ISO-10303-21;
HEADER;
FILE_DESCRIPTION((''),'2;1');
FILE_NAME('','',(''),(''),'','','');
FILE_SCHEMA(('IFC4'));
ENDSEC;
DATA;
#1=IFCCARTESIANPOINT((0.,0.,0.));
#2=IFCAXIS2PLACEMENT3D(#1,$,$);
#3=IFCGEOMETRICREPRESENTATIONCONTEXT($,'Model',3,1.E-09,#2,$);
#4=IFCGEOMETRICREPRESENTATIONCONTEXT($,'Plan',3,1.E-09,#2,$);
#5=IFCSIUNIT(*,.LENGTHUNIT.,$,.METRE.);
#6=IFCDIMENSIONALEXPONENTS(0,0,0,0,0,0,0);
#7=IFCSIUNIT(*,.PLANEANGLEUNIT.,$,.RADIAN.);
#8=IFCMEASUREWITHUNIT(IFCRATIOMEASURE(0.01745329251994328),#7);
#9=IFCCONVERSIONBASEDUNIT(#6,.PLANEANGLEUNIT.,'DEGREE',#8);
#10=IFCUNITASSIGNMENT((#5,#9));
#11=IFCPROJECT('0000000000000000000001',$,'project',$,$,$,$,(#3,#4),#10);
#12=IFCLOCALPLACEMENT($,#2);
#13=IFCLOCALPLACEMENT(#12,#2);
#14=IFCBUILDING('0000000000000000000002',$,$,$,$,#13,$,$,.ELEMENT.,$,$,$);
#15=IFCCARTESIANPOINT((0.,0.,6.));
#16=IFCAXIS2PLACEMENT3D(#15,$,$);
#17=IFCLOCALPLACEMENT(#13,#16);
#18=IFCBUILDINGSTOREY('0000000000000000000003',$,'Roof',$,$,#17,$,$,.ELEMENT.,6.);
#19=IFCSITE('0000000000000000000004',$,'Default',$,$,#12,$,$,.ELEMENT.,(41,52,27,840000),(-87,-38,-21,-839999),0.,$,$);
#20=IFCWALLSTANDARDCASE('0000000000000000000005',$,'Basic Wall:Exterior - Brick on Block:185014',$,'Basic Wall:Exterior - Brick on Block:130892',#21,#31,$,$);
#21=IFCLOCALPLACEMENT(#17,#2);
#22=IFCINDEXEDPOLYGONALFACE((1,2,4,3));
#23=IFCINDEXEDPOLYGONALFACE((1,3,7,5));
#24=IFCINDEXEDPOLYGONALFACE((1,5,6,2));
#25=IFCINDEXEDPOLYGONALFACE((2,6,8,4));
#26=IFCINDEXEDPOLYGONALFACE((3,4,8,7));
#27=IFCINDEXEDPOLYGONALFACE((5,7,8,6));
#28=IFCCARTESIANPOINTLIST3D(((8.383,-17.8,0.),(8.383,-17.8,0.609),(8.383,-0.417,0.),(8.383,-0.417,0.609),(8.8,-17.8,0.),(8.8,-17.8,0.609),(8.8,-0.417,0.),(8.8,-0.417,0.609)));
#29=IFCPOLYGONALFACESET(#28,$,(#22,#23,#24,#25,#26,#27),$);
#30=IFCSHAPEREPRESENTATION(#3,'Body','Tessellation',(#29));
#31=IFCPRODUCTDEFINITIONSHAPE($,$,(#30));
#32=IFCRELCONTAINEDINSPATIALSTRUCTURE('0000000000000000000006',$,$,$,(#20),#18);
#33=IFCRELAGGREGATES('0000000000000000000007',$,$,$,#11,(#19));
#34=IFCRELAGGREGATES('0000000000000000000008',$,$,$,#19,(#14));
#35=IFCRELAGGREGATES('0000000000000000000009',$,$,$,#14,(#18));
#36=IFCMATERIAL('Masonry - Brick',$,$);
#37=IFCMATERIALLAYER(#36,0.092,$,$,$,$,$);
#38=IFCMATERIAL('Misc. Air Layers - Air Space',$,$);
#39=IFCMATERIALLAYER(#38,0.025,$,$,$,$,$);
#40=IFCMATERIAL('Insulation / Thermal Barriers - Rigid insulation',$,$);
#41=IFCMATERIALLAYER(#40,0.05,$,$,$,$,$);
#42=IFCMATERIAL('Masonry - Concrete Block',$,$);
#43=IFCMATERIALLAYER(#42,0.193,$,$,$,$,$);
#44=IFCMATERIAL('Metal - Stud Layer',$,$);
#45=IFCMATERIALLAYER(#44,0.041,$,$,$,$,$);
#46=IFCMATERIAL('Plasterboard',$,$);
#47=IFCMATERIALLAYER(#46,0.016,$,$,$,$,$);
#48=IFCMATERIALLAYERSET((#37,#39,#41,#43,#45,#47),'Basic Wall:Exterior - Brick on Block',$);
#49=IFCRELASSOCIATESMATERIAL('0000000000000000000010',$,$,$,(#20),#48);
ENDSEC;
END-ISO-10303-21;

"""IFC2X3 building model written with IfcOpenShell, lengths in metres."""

from ifc_helpers import new_model, entity, si_unit, converted_unit, frame, frame_2d, origin, place, context, project, spatial, rectangle, extrude, material, layer, layer_set, layer_usage, element, save


model = new_model("IFC2X3")

# Units and contexts
model_context = context("Model", 3, precision=1e-09, world=origin())
plan_context = context("Plan", 3, precision=1e-09, world=origin())
ifc_project = project(units=[si_unit("LENGTHUNIT", "METRE"), converted_unit("PLANEANGLEUNIT", "DEGREE", entity("IfcRatioMeasure", 0.01745329251994328), si_unit("PLANEANGLEUNIT", "RADIAN"), dimensions=[0, 0, 0, 0, 0, 0, 0])], contexts=[model_context, plan_context])

# Site, building, storey
site_placement = place(None, origin())
site = spatial("IfcSite", under=ifc_project, at=site_placement, Name="Default", CompositionType="ELEMENT", RefLatitude=(41, 52, 27, 840000), RefLongitude=(-87, -38, -21, -839999), RefElevation=0.0)
building_placement = place(site_placement, origin())
building = spatial("IfcBuilding", under=site, at=building_placement, CompositionType="ELEMENT")
storey_placement = place(building_placement, frame((0.0, 0.0, 6.0)))
storey = spatial("IfcBuildingStorey", under=building, at=storey_placement, Name="Roof", CompositionType="ELEMENT", Elevation=6.0)

# Wall
ifc_material_1 = material(Name="Masonry - Brick")
ifc_layer_1 = layer(ifc_material_1, 0.092)
ifc_material_2 = material(Name="Misc. Air Layers - Air Space")
ifc_layer_2 = layer(ifc_material_2, 0.025)
ifc_material_3 = material(Name="Insulation / Thermal Barriers - Rigid insulation")
ifc_layer_3 = layer(ifc_material_3, 0.05)
ifc_material_4 = material(Name="Masonry - Concrete Block")
ifc_layer_4 = layer(ifc_material_4, 0.193)
ifc_material_5 = material(Name="Metal - Stud Layer")
ifc_layer_5 = layer(ifc_material_5, 0.041)
ifc_material_6 = material(Name="Plasterboard")
ifc_layer_6 = layer(ifc_material_6, 0.016)
ifc_layer_set = layer_set([ifc_layer_1, ifc_layer_2, ifc_layer_3, ifc_layer_4, ifc_layer_5, ifc_layer_6], Name="Basic Wall:Exterior - Brick on Block")
ifc_layer_usage = layer_usage(ifc_layer_set, "AXIS2", "NEGATIVE", 0.2085)
wall_placement = place(storey_placement, frame((8.5915, -0.417, 0.0), z_axis=(0.0, 0.0, 1.0), x_axis=(0.0, -1.0, 0.0)))
element("IfcWallStandardCase", 1, at=wall_placement, inside=storey, material=ifc_layer_usage, Name="Basic Wall:Exterior - Brick on Block:185014", ObjectType="Basic Wall:Exterior - Brick on Block:130892", context=model_context, shape_type="SweptSolid", body=[
    extrude(rectangle(XDim=17.383, YDim=0.417, at=frame_2d((8.6915, 0.0), x_axis=(-1.0, 0.0))), origin(), (0.0, 0.0, 1.0), 0.609),
])

save(model, "model.ifc")
